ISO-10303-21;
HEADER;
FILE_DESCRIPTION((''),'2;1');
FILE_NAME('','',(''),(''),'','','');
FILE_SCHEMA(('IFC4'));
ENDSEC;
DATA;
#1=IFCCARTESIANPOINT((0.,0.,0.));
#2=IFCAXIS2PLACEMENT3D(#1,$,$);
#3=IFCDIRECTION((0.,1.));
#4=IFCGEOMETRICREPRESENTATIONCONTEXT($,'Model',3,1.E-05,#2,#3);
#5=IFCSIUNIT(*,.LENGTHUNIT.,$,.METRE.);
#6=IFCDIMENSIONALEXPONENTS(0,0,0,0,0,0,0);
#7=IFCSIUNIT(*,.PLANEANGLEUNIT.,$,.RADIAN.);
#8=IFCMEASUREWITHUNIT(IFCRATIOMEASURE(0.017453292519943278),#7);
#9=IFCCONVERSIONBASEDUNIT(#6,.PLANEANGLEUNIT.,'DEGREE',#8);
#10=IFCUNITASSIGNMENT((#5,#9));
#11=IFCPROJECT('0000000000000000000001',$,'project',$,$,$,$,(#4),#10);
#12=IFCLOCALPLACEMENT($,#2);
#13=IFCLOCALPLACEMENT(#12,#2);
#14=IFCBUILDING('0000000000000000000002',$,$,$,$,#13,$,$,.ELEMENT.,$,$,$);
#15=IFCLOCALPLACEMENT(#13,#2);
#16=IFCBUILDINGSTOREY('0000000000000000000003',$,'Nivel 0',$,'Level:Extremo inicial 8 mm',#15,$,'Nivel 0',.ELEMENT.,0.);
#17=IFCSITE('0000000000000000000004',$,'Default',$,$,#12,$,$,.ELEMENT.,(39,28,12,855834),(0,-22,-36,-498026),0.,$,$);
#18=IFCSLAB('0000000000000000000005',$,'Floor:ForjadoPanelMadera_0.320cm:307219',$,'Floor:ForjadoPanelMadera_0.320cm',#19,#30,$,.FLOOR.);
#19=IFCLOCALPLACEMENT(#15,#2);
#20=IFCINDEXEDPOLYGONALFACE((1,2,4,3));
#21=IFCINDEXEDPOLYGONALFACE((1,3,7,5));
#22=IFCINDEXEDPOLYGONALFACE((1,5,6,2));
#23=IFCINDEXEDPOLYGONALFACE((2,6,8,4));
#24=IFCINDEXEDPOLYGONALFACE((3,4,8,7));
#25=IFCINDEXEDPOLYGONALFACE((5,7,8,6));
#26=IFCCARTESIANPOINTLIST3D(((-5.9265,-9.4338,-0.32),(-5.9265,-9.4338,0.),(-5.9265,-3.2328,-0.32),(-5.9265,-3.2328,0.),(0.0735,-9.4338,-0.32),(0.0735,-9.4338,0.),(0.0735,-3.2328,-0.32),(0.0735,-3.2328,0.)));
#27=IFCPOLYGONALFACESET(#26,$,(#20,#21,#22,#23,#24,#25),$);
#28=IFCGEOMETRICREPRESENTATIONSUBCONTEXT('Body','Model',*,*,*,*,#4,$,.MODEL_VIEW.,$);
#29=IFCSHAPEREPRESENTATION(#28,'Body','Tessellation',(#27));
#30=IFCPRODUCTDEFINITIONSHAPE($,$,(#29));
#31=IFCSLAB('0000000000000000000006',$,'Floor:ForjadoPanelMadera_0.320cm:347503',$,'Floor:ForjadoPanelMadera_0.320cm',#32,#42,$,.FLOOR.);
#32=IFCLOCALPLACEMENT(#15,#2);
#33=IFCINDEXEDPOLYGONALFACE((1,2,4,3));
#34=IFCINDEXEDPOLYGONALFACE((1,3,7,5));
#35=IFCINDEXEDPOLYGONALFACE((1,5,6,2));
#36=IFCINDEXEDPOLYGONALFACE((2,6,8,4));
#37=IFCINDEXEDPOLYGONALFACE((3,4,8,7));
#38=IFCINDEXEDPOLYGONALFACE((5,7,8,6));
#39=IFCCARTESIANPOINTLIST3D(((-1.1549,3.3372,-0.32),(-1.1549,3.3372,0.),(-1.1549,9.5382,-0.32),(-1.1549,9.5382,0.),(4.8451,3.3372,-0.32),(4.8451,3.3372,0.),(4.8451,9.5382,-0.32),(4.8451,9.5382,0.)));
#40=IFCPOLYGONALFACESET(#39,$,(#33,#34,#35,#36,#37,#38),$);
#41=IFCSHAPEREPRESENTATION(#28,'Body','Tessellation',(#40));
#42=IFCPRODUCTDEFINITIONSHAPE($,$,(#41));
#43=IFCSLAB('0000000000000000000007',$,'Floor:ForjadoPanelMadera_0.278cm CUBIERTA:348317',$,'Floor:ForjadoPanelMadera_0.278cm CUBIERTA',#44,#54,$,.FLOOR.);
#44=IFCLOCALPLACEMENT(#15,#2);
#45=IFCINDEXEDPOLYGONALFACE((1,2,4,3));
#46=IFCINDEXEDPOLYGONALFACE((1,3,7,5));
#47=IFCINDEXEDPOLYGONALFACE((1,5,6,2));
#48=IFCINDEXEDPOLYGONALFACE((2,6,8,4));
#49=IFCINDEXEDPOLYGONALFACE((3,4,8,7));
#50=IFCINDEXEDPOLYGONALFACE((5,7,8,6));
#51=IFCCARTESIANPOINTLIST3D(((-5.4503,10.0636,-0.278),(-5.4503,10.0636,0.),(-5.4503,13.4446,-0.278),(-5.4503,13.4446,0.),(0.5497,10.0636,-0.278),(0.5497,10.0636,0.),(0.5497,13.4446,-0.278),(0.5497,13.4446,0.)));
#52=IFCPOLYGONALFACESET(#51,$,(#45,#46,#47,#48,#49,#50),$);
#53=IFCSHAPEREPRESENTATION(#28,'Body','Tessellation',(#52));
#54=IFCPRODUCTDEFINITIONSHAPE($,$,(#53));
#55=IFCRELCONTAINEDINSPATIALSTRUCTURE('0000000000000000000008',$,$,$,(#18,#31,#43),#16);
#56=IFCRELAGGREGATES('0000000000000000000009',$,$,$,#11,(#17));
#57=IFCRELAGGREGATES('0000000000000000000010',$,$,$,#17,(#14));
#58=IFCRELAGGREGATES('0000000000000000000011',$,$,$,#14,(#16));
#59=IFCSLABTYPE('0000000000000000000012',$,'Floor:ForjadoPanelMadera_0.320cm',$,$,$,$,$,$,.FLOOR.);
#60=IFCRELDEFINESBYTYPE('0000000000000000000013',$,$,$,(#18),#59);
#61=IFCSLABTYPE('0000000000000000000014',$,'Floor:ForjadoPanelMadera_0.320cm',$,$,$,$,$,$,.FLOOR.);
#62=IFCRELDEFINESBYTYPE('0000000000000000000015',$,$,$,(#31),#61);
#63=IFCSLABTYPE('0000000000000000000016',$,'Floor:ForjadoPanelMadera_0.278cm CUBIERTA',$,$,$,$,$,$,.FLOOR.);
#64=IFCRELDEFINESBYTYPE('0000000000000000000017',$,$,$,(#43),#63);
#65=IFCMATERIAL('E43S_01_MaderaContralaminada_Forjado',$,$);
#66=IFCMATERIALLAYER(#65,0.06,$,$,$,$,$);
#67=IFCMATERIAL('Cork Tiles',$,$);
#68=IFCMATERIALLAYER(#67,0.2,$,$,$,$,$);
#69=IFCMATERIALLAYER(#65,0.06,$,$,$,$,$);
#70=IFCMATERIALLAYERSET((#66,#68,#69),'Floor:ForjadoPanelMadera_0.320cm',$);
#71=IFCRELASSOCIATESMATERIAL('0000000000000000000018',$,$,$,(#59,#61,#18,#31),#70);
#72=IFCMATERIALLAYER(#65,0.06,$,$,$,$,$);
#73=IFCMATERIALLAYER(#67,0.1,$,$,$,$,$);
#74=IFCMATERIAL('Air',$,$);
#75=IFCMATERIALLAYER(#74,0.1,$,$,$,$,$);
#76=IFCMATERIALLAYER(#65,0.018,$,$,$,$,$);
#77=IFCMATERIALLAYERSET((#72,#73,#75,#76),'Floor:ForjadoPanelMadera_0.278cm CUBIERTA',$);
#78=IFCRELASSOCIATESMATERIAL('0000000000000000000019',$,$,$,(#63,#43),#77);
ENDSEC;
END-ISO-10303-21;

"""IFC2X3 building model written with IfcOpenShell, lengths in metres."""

from ifc_helpers import new_model, entity, si_unit, converted_unit, direction, frame, frame_2d, origin, origin_2d_with_axis, place, context, subcontext, project, spatial, rectangle, extrude, material, layer, layer_set, layer_usage, type_object, element, save


model = new_model("IFC2X3")

# Units and contexts
model_context = context("Model", 3, precision=1e-05, world=origin(), true_north=direction((0.0, 1.0)))
body_context = subcontext(model_context, "Body", "Model", "MODEL_VIEW")
ifc_project = project(units=[si_unit("LENGTHUNIT", "METRE"), converted_unit("PLANEANGLEUNIT", "DEGREE", entity("IfcRatioMeasure", 0.017453292519943278), si_unit("PLANEANGLEUNIT", "RADIAN"), dimensions=[0, 0, 0, 0, 0, 0, 0])], contexts=[model_context])

# Site, building, storey
site_placement = place(None, origin())
site = spatial("IfcSite", under=ifc_project, at=site_placement, Name="Default", CompositionType="ELEMENT", RefLatitude=(39, 28, 12, 855834), RefLongitude=(0, -22, -36, -498026), RefElevation=0.0)
building_placement = place(site_placement, origin())
building = spatial("IfcBuilding", under=site, at=building_placement, CompositionType="ELEMENT")
storey_placement = place(building_placement, origin())
storey = spatial("IfcBuildingStorey", under=building, at=storey_placement, Name="Nivel 0", ObjectType="Level:Extremo inicial 8 mm", LongName="Nivel 0", CompositionType="ELEMENT", Elevation=0.0)

# Slabs
ifc_material_1 = material(Name="E43S_01_MaderaContralaminada_Forjado")
ifc_layer_1 = layer(ifc_material_1, 0.06)
ifc_material_2 = material(Name="Cork Tiles")
ifc_layer_2 = layer(ifc_material_2, 0.2)
ifc_layer_3 = layer(ifc_material_1, 0.06)
ifc_layer_set_1 = layer_set([ifc_layer_1, ifc_layer_2, ifc_layer_3], Name="Floor:ForjadoPanelMadera_0.320cm")
ifc_layer_usage_1 = layer_usage(ifc_layer_set_1, "AXIS3", "POSITIVE", 0.0)
slab_type_1 = type_object("IfcSlabType", Name="Floor:ForjadoPanelMadera_0.320cm", PredefinedType="FLOOR", material=ifc_layer_set_1)
slab_1_placement = place(storey_placement, origin())
element("IfcSlab", 1, at=slab_1_placement, inside=storey, type_object=slab_type_1, material=ifc_layer_usage_1, Name="Floor:ForjadoPanelMadera_0.320cm:307219", ObjectType="Floor:ForjadoPanelMadera_0.320cm", PredefinedType="FLOOR", context=body_context, shape_type="SweptSolid", body=[
    extrude(rectangle(XDim=6.201, YDim=6.0, at=frame_2d((0.0, 0.0), x_axis=(1.0, 0.0))), frame((-2.9265, -6.3333, 0.0), z_axis=(0.0, 0.0, -1.0), x_axis=(0.0, 1.0, 0.0)), (0.0, 0.0, 1.0), 0.32),
])
ifc_layer_usage_2 = layer_usage(ifc_layer_set_1, "AXIS3", "POSITIVE", 0.0)
slab_type_2 = type_object("IfcSlabType", Name="Floor:ForjadoPanelMadera_0.320cm", PredefinedType="FLOOR", material=ifc_layer_set_1)
slab_2_placement = place(storey_placement, origin())
element("IfcSlab", 2, at=slab_2_placement, inside=storey, type_object=slab_type_2, material=ifc_layer_usage_2, Name="Floor:ForjadoPanelMadera_0.320cm:347503", ObjectType="Floor:ForjadoPanelMadera_0.320cm", PredefinedType="FLOOR", context=body_context, shape_type="SweptSolid", body=[
    extrude(rectangle(XDim=6.201, YDim=6.0, at=origin_2d_with_axis()), frame((1.8451, 6.4377, 0.0), z_axis=(0.0, 0.0, -1.0), x_axis=(0.0, 1.0, 0.0)), (0.0, 0.0, 1.0), 0.32),
])
ifc_layer_4 = layer(ifc_material_1, 0.06)
ifc_layer_5 = layer(ifc_material_2, 0.1)
ifc_material_3 = material(Name="Air")
ifc_layer_6 = layer(ifc_material_3, 0.1)
ifc_layer_7 = layer(ifc_material_1, 0.018)
ifc_layer_set_2 = layer_set([ifc_layer_4, ifc_layer_5, ifc_layer_6, ifc_layer_7], Name="Floor:ForjadoPanelMadera_0.278cm CUBIERTA")
ifc_layer_usage_3 = layer_usage(ifc_layer_set_2, "AXIS3", "POSITIVE", 0.0)
slab_type_3 = type_object("IfcSlabType", Name="Floor:ForjadoPanelMadera_0.278cm CUBIERTA", PredefinedType="FLOOR", material=ifc_layer_set_2)
slab_3_placement = place(storey_placement, origin())
element("IfcSlab", 3, at=slab_3_placement, inside=storey, type_object=slab_type_3, material=ifc_layer_usage_3, Name="Floor:ForjadoPanelMadera_0.278cm CUBIERTA:348317", ObjectType="Floor:ForjadoPanelMadera_0.278cm CUBIERTA", PredefinedType="FLOOR", context=body_context, shape_type="SweptSolid", body=[
    extrude(rectangle(XDim=3.381, YDim=6.0, at=frame_2d((0.0, 0.0), x_axis=(1.0, 0.0))), frame((-2.4503, 11.7541, 0.0), z_axis=(0.0, 0.0, -1.0), x_axis=(0.0, 1.0, 0.0)), (0.0, 0.0, 1.0), 0.278),
])

save(model, "model.ifc")
